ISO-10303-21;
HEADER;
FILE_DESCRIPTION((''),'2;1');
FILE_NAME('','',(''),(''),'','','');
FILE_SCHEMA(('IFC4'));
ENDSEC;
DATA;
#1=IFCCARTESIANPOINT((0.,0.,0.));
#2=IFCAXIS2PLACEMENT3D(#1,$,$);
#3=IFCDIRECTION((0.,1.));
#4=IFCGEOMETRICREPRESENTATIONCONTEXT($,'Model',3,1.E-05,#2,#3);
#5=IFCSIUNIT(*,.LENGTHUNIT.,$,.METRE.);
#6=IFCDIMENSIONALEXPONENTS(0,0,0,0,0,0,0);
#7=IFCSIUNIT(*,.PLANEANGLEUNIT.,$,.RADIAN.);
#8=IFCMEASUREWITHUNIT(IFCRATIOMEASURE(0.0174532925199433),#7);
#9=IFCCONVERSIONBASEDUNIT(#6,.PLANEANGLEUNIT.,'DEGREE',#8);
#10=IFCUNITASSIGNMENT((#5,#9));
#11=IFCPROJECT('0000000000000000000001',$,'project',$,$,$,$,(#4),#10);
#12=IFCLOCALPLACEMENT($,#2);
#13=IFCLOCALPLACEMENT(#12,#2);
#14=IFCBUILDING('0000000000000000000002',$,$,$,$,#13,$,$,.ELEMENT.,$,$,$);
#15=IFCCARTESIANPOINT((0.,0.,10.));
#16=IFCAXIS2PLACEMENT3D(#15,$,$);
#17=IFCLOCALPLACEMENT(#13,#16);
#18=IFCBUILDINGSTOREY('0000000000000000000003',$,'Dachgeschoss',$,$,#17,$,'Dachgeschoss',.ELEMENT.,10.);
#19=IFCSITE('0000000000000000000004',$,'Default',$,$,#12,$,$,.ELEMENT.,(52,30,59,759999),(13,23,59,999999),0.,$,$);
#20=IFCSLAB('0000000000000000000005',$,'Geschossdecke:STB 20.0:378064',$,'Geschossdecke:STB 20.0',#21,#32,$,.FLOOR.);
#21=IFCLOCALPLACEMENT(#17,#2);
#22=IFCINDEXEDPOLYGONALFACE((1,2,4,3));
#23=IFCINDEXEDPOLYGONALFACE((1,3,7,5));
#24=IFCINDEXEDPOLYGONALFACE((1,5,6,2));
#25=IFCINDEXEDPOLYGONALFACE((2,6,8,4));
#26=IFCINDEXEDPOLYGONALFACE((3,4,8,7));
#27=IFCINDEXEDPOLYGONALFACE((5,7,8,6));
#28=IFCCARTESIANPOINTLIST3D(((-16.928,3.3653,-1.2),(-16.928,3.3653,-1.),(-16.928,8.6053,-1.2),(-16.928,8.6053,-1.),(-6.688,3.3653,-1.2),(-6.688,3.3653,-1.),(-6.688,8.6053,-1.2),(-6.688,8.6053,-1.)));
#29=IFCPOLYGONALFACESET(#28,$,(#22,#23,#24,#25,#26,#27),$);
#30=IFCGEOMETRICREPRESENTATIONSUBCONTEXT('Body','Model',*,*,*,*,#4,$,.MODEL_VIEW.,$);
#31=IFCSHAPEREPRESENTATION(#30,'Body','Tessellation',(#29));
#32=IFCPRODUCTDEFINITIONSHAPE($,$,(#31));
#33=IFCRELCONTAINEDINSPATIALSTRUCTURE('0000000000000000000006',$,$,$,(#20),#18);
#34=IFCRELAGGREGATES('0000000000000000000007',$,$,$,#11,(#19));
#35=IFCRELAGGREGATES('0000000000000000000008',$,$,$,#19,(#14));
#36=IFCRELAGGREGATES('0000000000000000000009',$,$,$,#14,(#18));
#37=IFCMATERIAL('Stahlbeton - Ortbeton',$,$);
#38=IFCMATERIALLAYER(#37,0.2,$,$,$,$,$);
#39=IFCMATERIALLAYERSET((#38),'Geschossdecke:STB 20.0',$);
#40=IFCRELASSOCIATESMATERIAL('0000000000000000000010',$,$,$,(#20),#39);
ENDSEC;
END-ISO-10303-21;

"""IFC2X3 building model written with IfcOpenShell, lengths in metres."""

from ifc_helpers import new_model, entity, si_unit, converted_unit, direction, frame, origin, origin_2d_with_axis, place, context, subcontext, project, spatial, rectangle, extrude, material, layer, layer_set, layer_usage, element, save


model = new_model("IFC2X3")

# Units and contexts
model_context = context("Model", 3, precision=1e-05, world=origin(), true_north=direction((0.0, 1.0)))
body_context = subcontext(model_context, "Body", "Model", "MODEL_VIEW")
ifc_project = project(units=[si_unit("LENGTHUNIT", "METRE"), converted_unit("PLANEANGLEUNIT", "DEGREE", entity("IfcRatioMeasure", 0.0174532925199433), si_unit("PLANEANGLEUNIT", "RADIAN"), dimensions=[0, 0, 0, 0, 0, 0, 0])], contexts=[model_context])

# Site, building, storey
site_placement = place(None, origin())
site = spatial("IfcSite", under=ifc_project, at=site_placement, Name="Default", CompositionType="ELEMENT", RefLatitude=(52, 30, 59, 759999), RefLongitude=(13, 23, 59, 999999), RefElevation=0.0)
building_placement = place(site_placement, origin())
building = spatial("IfcBuilding", under=site, at=building_placement, CompositionType="ELEMENT")
storey_placement = place(building_placement, frame((0.0, 0.0, 10.0)))
storey = spatial("IfcBuildingStorey", under=building, at=storey_placement, Name="Dachgeschoss", LongName="Dachgeschoss", CompositionType="ELEMENT", Elevation=10.0)

# Slab
ifc_material = material(Name="Stahlbeton - Ortbeton")
ifc_layer = layer(ifc_material, 0.2)
ifc_layer_set = layer_set([ifc_layer], Name="Geschossdecke:STB 20.0")
ifc_layer_usage_1 = layer_usage(ifc_layer_set, "AXIS3", "POSITIVE", 0.0)
slab_1_placement = place(storey_placement, origin())
element("IfcSlab", 1, at=slab_1_placement, inside=storey, material=ifc_layer_usage_1, Name="Geschossdecke:STB 20.0:378064", ObjectType="Geschossdecke:STB 20.0", PredefinedType="FLOOR", context=body_context, shape_type="SweptSolid", body=[
    extrude(rectangle(XDim=5.24, YDim=10.24, at=origin_2d_with_axis()), frame((-11.808, 5.9853, -1.0), z_axis=(0.0, 0.0, -1.0), x_axis=(0.0, 1.0, 0.0)), (0.0, 0.0, 1.0), 0.2),
])

save(model, "model.ifc")
